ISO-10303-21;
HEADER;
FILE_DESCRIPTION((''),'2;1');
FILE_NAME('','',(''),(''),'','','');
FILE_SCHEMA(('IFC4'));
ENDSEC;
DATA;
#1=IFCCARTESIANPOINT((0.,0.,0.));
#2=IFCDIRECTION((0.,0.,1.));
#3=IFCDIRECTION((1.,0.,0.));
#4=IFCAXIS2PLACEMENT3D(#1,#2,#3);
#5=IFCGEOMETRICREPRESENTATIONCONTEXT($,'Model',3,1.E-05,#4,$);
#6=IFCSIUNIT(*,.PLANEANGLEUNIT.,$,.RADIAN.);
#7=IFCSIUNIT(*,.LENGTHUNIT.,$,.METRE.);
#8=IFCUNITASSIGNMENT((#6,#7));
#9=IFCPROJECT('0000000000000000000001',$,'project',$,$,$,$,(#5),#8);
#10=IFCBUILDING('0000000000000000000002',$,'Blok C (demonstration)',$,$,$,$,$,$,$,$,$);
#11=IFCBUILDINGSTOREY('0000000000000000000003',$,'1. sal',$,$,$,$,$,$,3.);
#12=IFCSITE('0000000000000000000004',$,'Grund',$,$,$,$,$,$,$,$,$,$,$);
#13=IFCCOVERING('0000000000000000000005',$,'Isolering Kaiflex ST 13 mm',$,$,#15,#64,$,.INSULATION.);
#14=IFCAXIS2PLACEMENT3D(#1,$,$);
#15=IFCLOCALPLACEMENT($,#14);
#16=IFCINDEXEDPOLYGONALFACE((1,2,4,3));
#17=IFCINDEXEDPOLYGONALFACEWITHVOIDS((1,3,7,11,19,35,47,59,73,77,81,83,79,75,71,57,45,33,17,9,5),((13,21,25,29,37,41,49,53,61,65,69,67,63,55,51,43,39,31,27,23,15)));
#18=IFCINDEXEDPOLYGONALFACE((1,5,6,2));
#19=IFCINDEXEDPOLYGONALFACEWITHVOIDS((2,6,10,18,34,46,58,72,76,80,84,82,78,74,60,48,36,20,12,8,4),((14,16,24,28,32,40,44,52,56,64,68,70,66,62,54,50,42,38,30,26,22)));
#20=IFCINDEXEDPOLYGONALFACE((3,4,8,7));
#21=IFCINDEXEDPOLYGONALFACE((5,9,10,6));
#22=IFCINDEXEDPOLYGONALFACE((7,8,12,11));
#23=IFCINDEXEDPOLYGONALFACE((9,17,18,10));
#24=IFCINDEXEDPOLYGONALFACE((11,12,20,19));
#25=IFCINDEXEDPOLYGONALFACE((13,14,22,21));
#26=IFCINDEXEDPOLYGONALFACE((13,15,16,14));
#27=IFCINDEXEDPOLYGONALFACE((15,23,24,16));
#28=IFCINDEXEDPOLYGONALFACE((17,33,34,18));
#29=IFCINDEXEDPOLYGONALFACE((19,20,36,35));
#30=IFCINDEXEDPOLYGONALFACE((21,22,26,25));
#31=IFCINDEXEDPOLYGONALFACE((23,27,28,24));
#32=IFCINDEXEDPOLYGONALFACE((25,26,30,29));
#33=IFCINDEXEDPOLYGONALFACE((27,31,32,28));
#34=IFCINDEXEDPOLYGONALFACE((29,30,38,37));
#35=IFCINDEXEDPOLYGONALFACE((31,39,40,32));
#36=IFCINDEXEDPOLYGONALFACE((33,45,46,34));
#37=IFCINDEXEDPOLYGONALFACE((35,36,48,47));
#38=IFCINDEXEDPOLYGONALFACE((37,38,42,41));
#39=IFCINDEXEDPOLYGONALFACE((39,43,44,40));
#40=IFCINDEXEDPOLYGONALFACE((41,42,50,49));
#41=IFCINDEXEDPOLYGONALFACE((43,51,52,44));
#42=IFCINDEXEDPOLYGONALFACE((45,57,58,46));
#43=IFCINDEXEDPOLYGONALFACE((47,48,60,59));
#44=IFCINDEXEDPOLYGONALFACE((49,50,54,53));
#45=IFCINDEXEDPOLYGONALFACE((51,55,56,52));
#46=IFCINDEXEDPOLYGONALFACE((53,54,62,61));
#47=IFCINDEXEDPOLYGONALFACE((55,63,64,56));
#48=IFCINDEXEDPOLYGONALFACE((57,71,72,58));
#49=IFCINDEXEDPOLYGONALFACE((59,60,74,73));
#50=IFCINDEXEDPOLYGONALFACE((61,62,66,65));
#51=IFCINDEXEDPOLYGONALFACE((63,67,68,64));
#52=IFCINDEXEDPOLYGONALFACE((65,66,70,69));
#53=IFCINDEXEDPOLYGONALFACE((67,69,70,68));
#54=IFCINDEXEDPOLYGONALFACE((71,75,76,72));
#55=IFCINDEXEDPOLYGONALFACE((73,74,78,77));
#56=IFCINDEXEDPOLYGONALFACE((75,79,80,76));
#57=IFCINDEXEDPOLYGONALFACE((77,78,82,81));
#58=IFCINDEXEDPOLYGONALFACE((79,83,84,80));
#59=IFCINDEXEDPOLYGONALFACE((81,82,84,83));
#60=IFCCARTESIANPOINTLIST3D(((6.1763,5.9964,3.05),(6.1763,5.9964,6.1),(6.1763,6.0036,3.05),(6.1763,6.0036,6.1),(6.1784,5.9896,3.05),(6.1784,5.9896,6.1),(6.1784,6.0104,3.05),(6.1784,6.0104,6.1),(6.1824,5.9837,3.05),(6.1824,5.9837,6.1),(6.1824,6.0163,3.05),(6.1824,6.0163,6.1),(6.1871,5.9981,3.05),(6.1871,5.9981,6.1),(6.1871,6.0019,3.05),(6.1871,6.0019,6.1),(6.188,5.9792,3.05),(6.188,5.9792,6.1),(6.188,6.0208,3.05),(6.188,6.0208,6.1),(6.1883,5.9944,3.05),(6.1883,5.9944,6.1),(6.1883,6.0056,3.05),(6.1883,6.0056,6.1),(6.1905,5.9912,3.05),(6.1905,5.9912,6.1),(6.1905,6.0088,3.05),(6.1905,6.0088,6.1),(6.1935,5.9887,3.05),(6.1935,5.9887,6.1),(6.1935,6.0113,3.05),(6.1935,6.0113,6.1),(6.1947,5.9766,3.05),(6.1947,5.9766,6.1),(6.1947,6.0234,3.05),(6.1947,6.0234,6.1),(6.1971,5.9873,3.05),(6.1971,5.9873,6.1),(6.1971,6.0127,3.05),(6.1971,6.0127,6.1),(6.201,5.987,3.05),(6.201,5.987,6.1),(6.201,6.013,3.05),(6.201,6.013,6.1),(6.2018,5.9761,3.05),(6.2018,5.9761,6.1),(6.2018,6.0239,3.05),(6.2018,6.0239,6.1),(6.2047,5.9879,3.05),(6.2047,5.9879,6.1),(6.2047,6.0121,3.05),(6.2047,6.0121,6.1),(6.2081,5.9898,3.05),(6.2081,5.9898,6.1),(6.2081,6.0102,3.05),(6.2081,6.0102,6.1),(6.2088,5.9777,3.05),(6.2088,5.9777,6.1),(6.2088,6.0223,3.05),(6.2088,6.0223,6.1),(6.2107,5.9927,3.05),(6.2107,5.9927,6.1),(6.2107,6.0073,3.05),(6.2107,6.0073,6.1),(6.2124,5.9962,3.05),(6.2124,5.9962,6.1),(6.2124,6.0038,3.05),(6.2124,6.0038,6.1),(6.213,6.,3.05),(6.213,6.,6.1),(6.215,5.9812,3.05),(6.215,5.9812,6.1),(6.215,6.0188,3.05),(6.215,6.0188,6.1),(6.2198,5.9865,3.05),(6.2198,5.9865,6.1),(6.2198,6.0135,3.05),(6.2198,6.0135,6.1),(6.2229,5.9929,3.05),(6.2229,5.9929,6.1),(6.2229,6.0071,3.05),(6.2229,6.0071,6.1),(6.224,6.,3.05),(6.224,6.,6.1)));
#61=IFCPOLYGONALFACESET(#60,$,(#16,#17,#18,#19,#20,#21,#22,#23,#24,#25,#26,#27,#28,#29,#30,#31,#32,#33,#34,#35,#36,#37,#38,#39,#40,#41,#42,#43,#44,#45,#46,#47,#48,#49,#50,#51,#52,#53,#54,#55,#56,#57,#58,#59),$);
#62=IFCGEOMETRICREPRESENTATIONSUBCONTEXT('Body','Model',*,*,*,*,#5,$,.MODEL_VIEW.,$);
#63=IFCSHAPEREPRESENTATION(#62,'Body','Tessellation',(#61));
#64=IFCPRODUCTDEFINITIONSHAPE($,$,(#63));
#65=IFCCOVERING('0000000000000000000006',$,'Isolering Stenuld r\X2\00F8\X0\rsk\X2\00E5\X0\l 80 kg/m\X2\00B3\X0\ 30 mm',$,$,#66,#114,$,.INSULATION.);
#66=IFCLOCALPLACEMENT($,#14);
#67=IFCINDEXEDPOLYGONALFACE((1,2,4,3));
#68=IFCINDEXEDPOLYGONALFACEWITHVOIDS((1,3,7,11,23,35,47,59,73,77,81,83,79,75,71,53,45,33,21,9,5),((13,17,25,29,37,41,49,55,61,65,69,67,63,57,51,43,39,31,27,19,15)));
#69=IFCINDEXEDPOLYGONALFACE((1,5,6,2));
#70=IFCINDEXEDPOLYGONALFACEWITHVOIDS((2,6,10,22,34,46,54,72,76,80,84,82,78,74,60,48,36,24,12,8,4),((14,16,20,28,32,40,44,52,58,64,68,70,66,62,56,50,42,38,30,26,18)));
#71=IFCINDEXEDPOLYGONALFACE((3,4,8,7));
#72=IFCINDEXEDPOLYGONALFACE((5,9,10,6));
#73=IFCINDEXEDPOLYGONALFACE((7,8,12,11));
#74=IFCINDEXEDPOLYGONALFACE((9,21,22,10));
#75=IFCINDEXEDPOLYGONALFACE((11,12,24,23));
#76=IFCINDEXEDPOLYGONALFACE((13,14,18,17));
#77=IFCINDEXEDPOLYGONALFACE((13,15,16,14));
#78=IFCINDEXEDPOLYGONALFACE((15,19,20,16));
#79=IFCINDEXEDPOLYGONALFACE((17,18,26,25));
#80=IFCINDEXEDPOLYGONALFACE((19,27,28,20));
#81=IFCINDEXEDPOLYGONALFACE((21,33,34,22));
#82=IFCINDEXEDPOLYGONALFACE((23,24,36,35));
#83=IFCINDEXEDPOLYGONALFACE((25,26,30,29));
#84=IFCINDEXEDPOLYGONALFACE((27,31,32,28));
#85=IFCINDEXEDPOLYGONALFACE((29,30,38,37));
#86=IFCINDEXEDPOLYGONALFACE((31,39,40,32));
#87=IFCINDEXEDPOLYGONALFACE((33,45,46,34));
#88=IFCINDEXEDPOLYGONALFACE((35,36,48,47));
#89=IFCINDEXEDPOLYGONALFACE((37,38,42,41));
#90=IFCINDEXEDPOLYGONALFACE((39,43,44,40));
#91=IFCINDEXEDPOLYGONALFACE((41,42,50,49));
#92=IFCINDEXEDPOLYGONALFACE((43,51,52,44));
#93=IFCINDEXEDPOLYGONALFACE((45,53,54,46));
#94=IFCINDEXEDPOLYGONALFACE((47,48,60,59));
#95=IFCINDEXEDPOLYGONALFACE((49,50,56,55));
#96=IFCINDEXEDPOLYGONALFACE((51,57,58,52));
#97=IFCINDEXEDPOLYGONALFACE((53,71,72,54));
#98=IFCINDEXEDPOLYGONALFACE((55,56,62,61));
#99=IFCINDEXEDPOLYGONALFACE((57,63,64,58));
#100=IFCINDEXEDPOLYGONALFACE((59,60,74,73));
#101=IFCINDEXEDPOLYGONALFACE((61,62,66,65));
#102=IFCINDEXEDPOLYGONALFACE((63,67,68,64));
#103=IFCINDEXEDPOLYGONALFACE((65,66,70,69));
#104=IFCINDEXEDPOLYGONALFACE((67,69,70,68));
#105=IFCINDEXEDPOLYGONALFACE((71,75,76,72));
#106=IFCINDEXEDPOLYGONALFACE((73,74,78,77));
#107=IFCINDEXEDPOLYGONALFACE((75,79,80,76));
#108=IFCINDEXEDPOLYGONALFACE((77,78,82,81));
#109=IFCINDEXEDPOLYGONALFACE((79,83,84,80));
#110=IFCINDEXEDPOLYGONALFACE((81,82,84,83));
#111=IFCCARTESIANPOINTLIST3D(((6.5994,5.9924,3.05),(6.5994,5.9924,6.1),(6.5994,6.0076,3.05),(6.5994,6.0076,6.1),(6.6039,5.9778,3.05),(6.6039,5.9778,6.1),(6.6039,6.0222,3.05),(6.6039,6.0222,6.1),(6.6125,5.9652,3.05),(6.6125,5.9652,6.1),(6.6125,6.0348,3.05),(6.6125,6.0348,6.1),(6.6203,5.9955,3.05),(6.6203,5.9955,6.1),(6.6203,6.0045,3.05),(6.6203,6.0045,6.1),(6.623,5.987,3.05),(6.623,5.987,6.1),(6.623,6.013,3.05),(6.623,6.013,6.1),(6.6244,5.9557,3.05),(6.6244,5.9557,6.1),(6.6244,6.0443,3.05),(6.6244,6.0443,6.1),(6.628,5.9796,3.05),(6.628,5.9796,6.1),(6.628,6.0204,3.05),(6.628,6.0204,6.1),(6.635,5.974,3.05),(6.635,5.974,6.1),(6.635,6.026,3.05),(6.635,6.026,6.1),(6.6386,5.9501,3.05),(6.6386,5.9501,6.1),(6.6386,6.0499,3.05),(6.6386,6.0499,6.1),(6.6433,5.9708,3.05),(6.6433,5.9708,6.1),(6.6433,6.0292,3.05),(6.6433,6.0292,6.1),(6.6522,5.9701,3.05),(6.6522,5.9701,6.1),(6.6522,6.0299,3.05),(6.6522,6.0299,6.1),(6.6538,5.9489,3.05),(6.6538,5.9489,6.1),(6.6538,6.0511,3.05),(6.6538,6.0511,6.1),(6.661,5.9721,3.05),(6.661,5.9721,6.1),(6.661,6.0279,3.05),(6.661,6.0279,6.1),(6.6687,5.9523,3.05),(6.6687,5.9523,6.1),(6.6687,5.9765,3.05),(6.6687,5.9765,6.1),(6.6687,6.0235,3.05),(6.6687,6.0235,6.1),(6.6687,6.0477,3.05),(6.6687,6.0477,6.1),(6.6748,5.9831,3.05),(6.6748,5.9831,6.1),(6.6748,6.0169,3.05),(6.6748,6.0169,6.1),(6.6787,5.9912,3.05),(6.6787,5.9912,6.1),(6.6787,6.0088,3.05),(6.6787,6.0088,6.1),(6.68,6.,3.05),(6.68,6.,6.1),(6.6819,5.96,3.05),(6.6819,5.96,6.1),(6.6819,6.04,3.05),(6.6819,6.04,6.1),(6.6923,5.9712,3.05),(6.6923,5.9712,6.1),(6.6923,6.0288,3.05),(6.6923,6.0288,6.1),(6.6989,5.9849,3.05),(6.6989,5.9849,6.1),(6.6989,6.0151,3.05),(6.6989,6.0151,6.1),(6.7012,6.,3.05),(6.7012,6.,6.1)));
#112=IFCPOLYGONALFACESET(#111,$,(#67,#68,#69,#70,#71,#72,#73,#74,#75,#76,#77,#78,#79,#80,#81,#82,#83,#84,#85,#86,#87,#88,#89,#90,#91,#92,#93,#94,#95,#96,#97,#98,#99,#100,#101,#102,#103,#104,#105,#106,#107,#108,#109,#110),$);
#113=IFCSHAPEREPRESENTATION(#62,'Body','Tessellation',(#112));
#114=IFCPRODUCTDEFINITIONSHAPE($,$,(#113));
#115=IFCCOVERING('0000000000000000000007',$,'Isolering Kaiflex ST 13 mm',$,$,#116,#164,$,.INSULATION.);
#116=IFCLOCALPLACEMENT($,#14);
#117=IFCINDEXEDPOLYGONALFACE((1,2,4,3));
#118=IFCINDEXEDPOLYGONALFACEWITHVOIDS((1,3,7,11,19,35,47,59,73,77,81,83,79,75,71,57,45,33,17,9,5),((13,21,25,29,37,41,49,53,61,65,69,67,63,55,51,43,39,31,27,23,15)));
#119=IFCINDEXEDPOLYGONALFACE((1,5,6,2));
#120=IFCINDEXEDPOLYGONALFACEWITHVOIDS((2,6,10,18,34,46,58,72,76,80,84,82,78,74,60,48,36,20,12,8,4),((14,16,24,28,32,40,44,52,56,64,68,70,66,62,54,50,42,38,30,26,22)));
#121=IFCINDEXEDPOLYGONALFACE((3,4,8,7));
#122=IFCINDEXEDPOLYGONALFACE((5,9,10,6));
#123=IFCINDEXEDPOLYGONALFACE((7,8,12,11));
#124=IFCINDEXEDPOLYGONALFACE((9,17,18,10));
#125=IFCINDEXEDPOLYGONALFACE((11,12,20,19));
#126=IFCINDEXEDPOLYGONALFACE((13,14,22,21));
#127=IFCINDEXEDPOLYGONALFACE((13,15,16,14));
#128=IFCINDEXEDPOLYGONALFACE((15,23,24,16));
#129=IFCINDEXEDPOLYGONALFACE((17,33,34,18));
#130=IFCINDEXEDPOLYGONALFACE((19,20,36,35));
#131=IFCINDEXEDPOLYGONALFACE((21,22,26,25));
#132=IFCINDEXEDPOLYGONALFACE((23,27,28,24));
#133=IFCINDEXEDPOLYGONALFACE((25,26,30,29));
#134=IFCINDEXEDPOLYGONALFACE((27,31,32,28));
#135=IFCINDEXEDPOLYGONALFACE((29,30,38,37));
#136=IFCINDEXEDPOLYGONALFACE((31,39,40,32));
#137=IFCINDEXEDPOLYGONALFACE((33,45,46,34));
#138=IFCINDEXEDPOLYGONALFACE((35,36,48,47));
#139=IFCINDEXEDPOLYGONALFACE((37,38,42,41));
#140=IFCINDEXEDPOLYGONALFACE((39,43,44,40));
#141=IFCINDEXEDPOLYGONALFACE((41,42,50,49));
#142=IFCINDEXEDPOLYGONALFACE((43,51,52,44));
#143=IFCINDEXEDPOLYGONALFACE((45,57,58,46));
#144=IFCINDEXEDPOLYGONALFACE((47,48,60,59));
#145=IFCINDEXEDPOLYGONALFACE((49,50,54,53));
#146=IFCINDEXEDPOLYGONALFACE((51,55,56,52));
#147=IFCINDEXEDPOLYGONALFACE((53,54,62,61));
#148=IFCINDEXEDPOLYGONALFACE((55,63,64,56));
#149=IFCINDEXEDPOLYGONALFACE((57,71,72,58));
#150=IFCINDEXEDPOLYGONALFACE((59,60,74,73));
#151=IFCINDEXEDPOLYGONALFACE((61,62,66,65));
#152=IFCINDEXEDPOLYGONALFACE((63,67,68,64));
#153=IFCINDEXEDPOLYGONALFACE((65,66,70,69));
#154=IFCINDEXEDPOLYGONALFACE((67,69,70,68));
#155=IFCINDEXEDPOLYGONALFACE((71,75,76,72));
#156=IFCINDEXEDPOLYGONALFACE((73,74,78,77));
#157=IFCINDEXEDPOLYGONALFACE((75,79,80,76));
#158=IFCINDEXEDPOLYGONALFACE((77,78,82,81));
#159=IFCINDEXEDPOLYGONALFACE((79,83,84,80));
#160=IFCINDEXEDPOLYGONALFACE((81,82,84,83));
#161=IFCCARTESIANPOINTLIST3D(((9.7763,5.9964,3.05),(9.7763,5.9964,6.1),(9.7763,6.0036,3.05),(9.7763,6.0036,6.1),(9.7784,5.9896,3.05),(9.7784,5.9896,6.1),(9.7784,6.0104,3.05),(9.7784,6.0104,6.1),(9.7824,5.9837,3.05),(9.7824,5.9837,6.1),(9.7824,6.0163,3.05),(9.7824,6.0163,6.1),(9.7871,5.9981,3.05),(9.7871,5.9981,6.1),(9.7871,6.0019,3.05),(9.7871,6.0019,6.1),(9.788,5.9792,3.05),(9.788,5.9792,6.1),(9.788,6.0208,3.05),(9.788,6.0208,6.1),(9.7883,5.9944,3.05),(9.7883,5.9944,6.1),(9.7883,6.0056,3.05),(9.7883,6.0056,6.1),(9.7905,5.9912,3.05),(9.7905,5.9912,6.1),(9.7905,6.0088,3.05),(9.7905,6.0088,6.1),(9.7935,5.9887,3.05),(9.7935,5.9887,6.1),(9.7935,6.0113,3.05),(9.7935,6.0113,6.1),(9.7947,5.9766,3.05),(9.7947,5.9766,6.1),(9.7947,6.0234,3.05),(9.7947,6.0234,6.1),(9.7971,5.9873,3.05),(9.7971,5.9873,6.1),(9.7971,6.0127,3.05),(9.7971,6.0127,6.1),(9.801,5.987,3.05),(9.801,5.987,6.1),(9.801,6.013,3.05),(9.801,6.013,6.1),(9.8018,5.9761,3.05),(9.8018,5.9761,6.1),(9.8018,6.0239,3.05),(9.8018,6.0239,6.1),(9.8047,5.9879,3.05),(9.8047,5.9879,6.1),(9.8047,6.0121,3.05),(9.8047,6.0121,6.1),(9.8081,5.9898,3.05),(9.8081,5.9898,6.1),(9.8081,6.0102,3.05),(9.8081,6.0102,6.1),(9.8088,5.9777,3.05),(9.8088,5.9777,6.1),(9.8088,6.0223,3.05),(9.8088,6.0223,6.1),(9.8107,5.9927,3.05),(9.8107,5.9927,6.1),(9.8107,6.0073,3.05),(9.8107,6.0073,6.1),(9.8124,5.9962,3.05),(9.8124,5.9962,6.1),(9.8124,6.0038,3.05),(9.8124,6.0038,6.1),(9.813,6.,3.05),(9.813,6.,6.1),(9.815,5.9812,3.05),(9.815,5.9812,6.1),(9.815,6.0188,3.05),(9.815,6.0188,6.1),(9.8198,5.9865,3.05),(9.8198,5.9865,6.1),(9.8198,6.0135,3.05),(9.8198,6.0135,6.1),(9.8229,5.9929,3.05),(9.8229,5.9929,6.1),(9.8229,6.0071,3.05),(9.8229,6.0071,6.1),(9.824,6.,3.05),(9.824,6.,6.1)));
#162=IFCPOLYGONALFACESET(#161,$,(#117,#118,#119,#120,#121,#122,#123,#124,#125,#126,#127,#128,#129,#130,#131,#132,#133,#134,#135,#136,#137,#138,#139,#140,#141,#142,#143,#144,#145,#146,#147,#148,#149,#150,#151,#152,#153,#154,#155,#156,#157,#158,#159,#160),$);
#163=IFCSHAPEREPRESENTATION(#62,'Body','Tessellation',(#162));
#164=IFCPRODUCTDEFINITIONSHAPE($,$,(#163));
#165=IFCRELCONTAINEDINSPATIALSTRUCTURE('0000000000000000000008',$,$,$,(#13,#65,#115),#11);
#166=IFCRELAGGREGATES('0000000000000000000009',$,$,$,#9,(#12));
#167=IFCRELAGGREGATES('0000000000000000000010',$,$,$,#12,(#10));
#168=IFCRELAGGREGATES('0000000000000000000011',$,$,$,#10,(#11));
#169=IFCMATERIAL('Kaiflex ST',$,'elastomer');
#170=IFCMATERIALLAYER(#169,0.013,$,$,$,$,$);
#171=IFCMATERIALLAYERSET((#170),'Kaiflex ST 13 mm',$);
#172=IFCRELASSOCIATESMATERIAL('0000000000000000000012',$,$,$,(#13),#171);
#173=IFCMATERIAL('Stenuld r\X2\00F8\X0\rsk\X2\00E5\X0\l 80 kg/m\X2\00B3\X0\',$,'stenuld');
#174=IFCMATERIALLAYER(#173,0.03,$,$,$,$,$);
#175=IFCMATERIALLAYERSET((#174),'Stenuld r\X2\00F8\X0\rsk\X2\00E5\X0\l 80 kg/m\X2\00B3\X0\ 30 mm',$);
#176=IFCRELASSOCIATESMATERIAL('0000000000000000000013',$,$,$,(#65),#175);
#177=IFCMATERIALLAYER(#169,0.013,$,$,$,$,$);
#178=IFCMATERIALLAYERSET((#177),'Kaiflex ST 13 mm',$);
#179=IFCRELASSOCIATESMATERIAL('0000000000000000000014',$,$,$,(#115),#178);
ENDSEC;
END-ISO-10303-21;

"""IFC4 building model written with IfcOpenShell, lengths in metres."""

from ifc_helpers import new_model, si_unit, frame, origin_with_axes, place, context, subcontext, project, spatial, hollow_circle, extrude, material, layer, layer_set, element, save


model = new_model("IFC4")

# Units and contexts
model_context = context("Model", 3, precision=1e-05, world=origin_with_axes())
body_context = subcontext(model_context, "Body", "Model", "MODEL_VIEW")
ifc_project = project(units=[si_unit("PLANEANGLEUNIT", "RADIAN"), si_unit("LENGTHUNIT", "METRE")], contexts=[model_context])

# Site, building, storey
site = spatial("IfcSite", under=ifc_project, Name="Grund")
building = spatial("IfcBuilding", under=site, Name="Blok C (demonstration)")
storey = spatial("IfcBuildingStorey", under=building, Name="1. sal", Elevation=3.0)

# Coverings
ifc_material_1 = material(Name="Kaiflex ST", Category="elastomer")
ifc_layer_1 = layer(ifc_material_1, 0.013)
ifc_layer_set_1 = layer_set([ifc_layer_1], Name="Kaiflex ST 13 mm")
covering_1_placement = place(None, origin_with_axes())
element("IfcCovering", 1, at=covering_1_placement, inside=storey, material=ifc_layer_set_1, Name="Isolering Kaiflex ST 13 mm", PredefinedType="INSULATION", context=body_context, shape_type="SweptSolid", body=[
    extrude(hollow_circle(Radius=0.024, WallThickness=0.011), frame((6.2, 6.0, 3.05), z_axis=(0.0, 0.0, 1.0), x_axis=(1.0, 0.0, 0.0)), (0.0, 0.0, 1.0), 3.05),
])
ifc_material_2 = material(Name="Stenuld rørskål 80 kg/m³", Category="stenuld")
ifc_layer_2 = layer(ifc_material_2, 0.03)
ifc_layer_set_2 = layer_set([ifc_layer_2], Name="Stenuld rørskål 80 kg/m³ 30 mm")
covering_2_placement = place(None, origin_with_axes())
element("IfcCovering", 2, at=covering_2_placement, inside=storey, material=ifc_layer_set_2, Name="Isolering Stenuld rørskål 80 kg/m³ 30 mm", PredefinedType="INSULATION", context=body_context, shape_type="SweptSolid", body=[
    extrude(hollow_circle(Radius=0.0512, WallThickness=0.0212), frame((6.65, 6.0, 3.05), z_axis=(0.0, 0.0, 1.0), x_axis=(1.0, 0.0, 0.0)), (0.0, 0.0, 1.0), 3.05),
])
ifc_layer_3 = layer(ifc_material_1, 0.013)
ifc_layer_set_3 = layer_set([ifc_layer_3], Name="Kaiflex ST 13 mm")
covering_3_placement = place(None, origin_with_axes())
element("IfcCovering", 3, at=covering_3_placement, inside=storey, material=ifc_layer_set_3, Name="Isolering Kaiflex ST 13 mm", PredefinedType="INSULATION", context=body_context, shape_type="SweptSolid", body=[
    extrude(hollow_circle(Radius=0.024, WallThickness=0.011), frame((9.8, 6.0, 3.05), z_axis=(0.0, 0.0, 1.0), x_axis=(1.0, 0.0, 0.0)), (0.0, 0.0, 1.0), 3.05),
])

save(model, "model.ifc")
